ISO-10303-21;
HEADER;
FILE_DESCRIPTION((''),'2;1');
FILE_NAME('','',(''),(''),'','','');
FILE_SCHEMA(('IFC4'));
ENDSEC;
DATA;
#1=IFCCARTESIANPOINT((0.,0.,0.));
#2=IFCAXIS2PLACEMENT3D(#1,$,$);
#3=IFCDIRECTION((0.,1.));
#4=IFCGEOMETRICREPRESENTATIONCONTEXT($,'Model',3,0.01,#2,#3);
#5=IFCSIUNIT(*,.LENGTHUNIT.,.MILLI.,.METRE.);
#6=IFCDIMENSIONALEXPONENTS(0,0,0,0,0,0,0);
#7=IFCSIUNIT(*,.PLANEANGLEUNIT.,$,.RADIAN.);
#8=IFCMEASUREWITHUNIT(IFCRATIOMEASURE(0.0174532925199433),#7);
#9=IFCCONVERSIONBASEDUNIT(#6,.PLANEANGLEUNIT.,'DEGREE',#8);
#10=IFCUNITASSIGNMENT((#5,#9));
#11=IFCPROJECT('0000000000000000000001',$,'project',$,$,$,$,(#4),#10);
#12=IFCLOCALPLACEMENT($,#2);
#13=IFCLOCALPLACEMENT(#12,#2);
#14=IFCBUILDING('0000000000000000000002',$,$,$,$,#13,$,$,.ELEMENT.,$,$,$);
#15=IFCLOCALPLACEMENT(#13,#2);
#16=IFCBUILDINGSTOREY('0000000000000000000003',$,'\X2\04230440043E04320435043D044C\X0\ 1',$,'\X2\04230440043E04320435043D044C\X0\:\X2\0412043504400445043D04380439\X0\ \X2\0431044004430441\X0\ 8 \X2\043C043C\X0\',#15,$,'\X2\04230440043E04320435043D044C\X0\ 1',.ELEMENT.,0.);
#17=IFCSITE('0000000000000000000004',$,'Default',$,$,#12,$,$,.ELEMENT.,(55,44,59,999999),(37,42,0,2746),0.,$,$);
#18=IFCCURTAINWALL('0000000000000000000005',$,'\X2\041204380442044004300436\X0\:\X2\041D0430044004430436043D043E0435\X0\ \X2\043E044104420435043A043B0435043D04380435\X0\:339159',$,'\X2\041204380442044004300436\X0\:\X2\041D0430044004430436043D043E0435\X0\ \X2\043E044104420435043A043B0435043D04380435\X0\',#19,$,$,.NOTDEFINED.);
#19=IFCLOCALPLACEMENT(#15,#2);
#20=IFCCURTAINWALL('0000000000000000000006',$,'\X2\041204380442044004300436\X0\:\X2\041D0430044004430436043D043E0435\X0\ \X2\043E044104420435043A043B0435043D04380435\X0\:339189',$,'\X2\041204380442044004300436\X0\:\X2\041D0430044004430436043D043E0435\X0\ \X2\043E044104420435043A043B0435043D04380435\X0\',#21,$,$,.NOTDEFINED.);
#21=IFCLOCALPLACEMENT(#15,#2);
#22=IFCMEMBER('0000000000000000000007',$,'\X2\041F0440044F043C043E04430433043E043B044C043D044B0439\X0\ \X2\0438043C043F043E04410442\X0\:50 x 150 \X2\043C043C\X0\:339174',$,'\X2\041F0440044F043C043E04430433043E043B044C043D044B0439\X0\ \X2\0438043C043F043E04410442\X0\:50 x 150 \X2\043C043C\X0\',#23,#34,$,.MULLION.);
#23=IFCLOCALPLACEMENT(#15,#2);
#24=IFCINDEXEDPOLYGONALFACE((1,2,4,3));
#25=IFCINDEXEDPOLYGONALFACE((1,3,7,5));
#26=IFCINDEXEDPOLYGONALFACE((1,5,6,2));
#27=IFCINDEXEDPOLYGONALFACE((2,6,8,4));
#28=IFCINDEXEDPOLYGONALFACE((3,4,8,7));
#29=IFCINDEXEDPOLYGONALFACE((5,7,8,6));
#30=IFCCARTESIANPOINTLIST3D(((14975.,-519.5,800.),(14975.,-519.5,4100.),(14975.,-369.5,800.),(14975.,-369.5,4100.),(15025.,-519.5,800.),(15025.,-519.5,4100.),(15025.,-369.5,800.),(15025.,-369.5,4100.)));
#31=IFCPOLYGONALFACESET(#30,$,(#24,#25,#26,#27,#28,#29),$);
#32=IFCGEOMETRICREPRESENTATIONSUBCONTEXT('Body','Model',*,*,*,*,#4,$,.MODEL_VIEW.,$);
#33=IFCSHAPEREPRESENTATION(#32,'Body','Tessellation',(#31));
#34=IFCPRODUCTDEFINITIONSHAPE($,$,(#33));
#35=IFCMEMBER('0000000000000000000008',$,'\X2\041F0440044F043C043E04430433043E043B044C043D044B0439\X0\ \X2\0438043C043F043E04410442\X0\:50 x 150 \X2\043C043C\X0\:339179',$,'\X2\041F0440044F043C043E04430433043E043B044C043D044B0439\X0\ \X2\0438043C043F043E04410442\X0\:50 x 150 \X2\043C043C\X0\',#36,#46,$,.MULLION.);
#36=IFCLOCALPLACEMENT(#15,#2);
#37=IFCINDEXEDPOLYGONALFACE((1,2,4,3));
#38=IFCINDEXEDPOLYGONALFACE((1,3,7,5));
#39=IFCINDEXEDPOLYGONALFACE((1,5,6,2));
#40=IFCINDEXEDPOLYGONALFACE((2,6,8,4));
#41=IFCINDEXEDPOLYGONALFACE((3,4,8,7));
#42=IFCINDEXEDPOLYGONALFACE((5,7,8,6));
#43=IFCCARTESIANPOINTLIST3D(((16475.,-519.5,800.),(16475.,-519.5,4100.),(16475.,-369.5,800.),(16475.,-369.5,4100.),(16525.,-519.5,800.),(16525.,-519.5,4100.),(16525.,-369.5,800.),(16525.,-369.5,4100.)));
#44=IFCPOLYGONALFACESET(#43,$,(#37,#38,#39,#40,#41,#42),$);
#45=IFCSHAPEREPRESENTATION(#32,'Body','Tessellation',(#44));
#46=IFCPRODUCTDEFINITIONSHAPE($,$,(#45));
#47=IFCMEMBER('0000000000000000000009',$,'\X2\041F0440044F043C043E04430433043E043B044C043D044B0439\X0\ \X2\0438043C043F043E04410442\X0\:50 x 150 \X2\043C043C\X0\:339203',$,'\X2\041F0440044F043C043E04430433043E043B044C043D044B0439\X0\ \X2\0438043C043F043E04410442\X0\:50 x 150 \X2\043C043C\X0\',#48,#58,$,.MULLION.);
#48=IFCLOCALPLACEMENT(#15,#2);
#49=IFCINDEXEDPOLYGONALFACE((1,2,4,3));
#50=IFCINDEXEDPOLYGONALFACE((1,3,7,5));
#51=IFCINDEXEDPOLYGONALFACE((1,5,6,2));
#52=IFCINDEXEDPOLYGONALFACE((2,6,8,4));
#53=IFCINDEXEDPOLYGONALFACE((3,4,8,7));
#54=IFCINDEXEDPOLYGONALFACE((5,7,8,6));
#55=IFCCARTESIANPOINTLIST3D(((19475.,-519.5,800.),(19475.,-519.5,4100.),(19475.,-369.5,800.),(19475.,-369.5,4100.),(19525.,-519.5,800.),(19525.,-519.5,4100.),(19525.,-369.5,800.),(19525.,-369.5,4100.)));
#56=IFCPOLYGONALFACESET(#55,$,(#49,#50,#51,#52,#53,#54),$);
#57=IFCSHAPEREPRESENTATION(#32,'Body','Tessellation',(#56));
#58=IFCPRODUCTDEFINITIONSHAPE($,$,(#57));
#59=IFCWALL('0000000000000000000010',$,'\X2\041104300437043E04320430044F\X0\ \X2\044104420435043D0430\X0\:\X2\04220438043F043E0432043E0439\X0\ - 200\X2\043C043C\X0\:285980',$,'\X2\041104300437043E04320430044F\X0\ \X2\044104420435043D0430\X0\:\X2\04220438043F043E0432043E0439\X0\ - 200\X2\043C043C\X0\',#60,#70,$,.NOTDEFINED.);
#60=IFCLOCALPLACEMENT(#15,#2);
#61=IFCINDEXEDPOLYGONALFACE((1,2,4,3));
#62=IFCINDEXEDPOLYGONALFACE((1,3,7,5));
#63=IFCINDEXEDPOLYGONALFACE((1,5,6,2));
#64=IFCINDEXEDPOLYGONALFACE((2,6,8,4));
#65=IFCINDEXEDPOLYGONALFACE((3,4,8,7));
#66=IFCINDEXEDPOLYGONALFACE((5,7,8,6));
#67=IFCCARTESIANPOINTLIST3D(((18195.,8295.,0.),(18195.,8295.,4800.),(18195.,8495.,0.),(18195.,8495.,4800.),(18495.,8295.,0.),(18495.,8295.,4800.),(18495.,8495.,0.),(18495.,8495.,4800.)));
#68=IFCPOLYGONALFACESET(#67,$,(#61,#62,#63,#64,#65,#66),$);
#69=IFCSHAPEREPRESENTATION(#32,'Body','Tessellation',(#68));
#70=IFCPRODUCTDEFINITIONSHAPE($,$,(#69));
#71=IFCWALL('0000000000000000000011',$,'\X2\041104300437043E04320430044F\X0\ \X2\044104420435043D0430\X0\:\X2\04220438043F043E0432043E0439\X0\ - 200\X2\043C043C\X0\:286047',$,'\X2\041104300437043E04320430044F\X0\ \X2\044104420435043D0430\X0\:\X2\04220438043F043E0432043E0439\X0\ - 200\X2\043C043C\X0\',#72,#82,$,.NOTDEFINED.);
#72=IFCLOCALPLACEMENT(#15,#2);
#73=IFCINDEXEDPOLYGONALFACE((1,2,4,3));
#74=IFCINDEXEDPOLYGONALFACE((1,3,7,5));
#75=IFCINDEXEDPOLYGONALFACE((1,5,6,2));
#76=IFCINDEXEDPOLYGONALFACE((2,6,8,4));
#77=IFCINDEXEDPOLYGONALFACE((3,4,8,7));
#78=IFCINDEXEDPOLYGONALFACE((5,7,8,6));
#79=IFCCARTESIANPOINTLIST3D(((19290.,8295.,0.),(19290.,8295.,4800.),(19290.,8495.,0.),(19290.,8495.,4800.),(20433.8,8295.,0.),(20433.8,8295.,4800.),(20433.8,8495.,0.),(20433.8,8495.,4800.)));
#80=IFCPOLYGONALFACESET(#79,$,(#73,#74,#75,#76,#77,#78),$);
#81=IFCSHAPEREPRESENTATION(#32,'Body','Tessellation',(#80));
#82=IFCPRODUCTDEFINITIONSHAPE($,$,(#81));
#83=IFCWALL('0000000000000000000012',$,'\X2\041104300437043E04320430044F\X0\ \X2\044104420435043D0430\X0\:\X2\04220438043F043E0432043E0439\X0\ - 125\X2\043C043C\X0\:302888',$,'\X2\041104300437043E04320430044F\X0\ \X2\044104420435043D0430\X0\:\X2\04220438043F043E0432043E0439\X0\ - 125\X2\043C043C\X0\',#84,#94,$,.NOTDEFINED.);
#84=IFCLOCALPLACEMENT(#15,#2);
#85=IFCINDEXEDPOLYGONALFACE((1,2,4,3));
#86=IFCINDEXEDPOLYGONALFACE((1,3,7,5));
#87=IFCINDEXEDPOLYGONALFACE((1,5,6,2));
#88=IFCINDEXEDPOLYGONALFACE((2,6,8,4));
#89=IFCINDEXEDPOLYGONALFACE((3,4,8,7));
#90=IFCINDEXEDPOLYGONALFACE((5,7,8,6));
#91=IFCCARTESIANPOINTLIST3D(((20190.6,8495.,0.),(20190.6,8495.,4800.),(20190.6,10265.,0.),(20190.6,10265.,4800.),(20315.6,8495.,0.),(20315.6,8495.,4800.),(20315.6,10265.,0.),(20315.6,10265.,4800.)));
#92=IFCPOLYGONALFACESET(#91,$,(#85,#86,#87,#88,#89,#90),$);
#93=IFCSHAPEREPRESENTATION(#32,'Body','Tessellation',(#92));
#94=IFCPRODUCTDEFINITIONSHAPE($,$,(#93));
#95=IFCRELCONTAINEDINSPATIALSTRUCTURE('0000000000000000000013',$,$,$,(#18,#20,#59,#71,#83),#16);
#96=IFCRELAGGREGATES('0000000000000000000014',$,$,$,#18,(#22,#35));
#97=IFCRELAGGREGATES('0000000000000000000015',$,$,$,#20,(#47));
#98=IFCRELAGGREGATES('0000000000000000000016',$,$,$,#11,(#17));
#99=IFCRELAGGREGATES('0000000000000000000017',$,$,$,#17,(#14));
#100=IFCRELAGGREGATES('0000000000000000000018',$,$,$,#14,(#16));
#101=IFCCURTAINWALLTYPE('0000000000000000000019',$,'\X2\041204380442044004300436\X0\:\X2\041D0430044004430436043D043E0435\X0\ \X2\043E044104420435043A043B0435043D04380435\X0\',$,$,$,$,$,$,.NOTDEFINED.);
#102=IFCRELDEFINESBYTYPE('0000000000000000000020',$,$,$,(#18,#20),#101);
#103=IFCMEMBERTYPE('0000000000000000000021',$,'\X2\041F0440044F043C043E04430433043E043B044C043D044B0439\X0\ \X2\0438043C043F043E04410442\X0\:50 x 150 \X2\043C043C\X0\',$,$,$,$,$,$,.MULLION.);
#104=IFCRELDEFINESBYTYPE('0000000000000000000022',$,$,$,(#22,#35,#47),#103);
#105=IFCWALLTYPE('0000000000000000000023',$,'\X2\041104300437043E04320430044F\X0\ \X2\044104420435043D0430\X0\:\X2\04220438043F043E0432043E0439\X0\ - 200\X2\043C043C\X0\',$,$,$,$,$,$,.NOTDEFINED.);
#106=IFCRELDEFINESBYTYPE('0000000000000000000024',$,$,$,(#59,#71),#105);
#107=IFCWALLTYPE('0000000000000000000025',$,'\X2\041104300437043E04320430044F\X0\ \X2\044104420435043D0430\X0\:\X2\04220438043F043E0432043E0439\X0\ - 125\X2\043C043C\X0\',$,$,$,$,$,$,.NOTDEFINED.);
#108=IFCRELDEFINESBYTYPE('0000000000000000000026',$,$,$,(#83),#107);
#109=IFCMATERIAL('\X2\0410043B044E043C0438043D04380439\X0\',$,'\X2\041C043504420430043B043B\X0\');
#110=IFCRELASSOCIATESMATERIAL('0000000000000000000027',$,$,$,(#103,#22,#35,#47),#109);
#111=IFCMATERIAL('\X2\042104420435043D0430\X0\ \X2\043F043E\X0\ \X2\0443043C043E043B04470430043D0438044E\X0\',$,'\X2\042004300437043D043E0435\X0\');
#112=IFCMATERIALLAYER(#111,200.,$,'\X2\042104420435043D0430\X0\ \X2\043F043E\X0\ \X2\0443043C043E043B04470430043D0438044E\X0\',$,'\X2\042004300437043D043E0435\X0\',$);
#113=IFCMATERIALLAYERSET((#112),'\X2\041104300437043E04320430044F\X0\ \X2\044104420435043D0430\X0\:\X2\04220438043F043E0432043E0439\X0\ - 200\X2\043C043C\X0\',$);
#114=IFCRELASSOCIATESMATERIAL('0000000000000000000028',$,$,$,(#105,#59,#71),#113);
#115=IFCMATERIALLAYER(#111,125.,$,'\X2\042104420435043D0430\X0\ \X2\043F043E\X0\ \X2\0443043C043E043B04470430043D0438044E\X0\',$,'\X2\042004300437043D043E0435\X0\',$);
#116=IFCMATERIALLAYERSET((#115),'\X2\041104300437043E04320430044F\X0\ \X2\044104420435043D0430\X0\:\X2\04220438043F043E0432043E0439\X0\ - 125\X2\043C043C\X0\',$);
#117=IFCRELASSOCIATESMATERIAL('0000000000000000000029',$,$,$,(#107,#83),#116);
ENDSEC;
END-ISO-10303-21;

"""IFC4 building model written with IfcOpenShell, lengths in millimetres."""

from ifc_helpers import new_model, entity, si_unit, converted_unit, direction, frame, frame_2d, origin, origin_2d_with_axis, place, context, subcontext, project, spatial, rectangle, extrude, source, transform, mapped, material, layer, layer_set, layer_usage, material_profile, profile_set, profile_usage, type_object, type_shapes, element, aggregate, save


model = new_model("IFC4")

# Units and contexts
model_context = context("Model", 3, precision=0.01, world=origin(), true_north=direction((0.0, 1.0)))
body_context = subcontext(model_context, "Body", "Model", "MODEL_VIEW")
ifc_project = project(units=[si_unit("LENGTHUNIT", "METRE", prefix="MILLI"), converted_unit("PLANEANGLEUNIT", "DEGREE", entity("IfcRatioMeasure", 0.0174532925199433), si_unit("PLANEANGLEUNIT", "RADIAN"), dimensions=[0, 0, 0, 0, 0, 0, 0])], contexts=[model_context])

# Site, building, storey
site_placement = place(None, origin())
site = spatial("IfcSite", under=ifc_project, at=site_placement, Name="Default", CompositionType="ELEMENT", RefLatitude=(55, 44, 59, 999999), RefLongitude=(37, 42, 0, 2746), RefElevation=0.0)
building_placement = place(site_placement, origin())
building = spatial("IfcBuilding", under=site, at=building_placement, CompositionType="ELEMENT")
storey_placement = place(building_placement, origin())
storey = spatial("IfcBuildingStorey", under=building, at=storey_placement, Name="Уровень 1", ObjectType="Уровень:Верхний брус 8 мм", LongName="Уровень 1", CompositionType="ELEMENT", Elevation=0.0)

# Curtain wall
curtain_wall_type = type_object("IfcCurtainWallType", Name="Витраж:Наружное остекление", PredefinedType="NOTDEFINED")
curtain_wall_1_placement = place(storey_placement, origin())
curtain_wall_1 = element("IfcCurtainWall", 1, at=curtain_wall_1_placement, inside=storey, type_object=curtain_wall_type, Name="Витраж:Наружное остекление:339159", ObjectType="Витраж:Наружное остекление", PredefinedType="NOTDEFINED")
ifc_material_1 = material(Name="Алюминий", Category="Металл")
ifc_material_profile = material_profile(ifc_material_1, rectangle(XDim=150.0, YDim=50.0, at=origin_2d_with_axis()), Name="50 x 150 мм")
ifc_profile_set = profile_set([ifc_material_profile], Name="50 x 150 мм")

# Curtain wall
curtain_wall_2_placement = place(storey_placement, origin())
curtain_wall_2 = element("IfcCurtainWall", 2, at=curtain_wall_2_placement, inside=storey, type_object=curtain_wall_type, Name="Витраж:Наружное остекление:339189", ObjectType="Витраж:Наружное остекление", PredefinedType="NOTDEFINED")

# Members
member_type_1 = type_object("IfcMemberType", Name="Прямоугольный импост:50 x 150 мм", PredefinedType="MULLION", material=ifc_profile_set)
shared_shape_1 = source(origin(), body_context, "Body", "SweptSolid", [
    extrude(rectangle(XDim=150.0, YDim=50.0, at=origin_2d_with_axis()), frame((0.0, 0.0, -3300.0), z_axis=(0.0, 0.0, 1.0), x_axis=(0.0, -1.0, 0.0)), (0.0, 0.0, 1.0), 3300.0),
])
type_shapes(member_type_1, [shared_shape_1])
ifc_profile_usage_1 = profile_usage(ifc_profile_set)
member_1_placement = place(storey_placement, frame((15000.0, -444.5, 800.0), z_axis=(0.0, 0.0, -1.0), x_axis=(1.0, 0.0, 0.0)))
member_1 = element("IfcMember", 3, at=member_1_placement, type_object=member_type_1, material=ifc_profile_usage_1, Name="Прямоугольный импост:50 x 150 мм:339174", ObjectType="Прямоугольный импост:50 x 150 мм", PredefinedType="MULLION", context=body_context, shape_type="MappedRepresentation", body=[
    mapped(shared_shape_1, transform((0.0, 0.0, 0.0), scale=1.0)),
])
ifc_profile_usage_2 = profile_usage(ifc_profile_set)
member_2_placement = place(storey_placement, frame((16500.0, -444.5, 800.0), z_axis=(0.0, 0.0, -1.0), x_axis=(1.0, 0.0, 0.0)))
member_2 = element("IfcMember", 4, at=member_2_placement, type_object=member_type_1, material=ifc_profile_usage_2, Name="Прямоугольный импост:50 x 150 мм:339179", ObjectType="Прямоугольный импост:50 x 150 мм", PredefinedType="MULLION", context=body_context, shape_type="MappedRepresentation", body=[
    mapped(shared_shape_1, transform((0.0, 0.0, 0.0), scale=1.0)),
])
ifc_profile_usage_3 = profile_usage(ifc_profile_set)
member_3_placement = place(storey_placement, frame((19500.0, -444.5, 800.0), z_axis=(0.0, 0.0, -1.0), x_axis=(1.0, 0.0, 0.0)))
member_3 = element("IfcMember", 5, at=member_3_placement, type_object=member_type_1, material=ifc_profile_usage_3, Name="Прямоугольный импост:50 x 150 мм:339203", ObjectType="Прямоугольный импост:50 x 150 мм", PredefinedType="MULLION", context=body_context, shape_type="MappedRepresentation", body=[
    mapped(shared_shape_1, transform((0.0, 0.0, 0.0), scale=1.0)),
])

aggregate(curtain_wall_1, [member_1, member_2])
aggregate(curtain_wall_2, [member_3])

# Walls
ifc_material_2 = material(Name="Стена по умолчанию", Category="Разное")
ifc_layer_1 = layer(ifc_material_2, 200.0, Name="Стена по умолчанию", Category="Разное")
ifc_layer_set_1 = layer_set([ifc_layer_1], Name="Базовая стена:Типовой - 200мм")
ifc_layer_usage_1 = layer_usage(ifc_layer_set_1, "AXIS2", "NEGATIVE", 100.0)
wall_type_1 = type_object("IfcWallType", Name="Базовая стена:Типовой - 200мм", PredefinedType="NOTDEFINED", material=ifc_layer_set_1)
wall_1_placement = place(storey_placement, frame((18195.0, 8395.0, 0.0)))
element("IfcWall", 6, at=wall_1_placement, inside=storey, type_object=wall_type_1, material=ifc_layer_usage_1, Name="Базовая стена:Типовой - 200мм:285980", ObjectType="Базовая стена:Типовой - 200мм", PredefinedType="NOTDEFINED", context=body_context, shape_type="SweptSolid", body=[
    extrude(rectangle(XDim=300.0, YDim=200.0, at=frame_2d((150.0, 0.0), x_axis=(-1.0, 0.0))), origin(), (0.0, 0.0, 1.0), 4800.0),
])
ifc_layer_usage_2 = layer_usage(ifc_layer_set_1, "AXIS2", "NEGATIVE", 100.0)
wall_2_placement = place(storey_placement, frame((19290.0, 8395.0, 0.0)))
element("IfcWall", 7, at=wall_2_placement, inside=storey, type_object=wall_type_1, material=ifc_layer_usage_2, Name="Базовая стена:Типовой - 200мм:286047", ObjectType="Базовая стена:Типовой - 200мм", PredefinedType="NOTDEFINED", context=body_context, shape_type="SweptSolid", body=[
    extrude(rectangle(XDim=1143.8, YDim=200.0, at=frame_2d((571.9, 0.0), x_axis=(-1.0, 0.0))), origin(), (0.0, 0.0, 1.0), 4800.0),
])
ifc_layer_2 = layer(ifc_material_2, 125.0, Name="Стена по умолчанию", Category="Разное")
ifc_layer_set_2 = layer_set([ifc_layer_2], Name="Базовая стена:Типовой - 125мм")
ifc_layer_usage_3 = layer_usage(ifc_layer_set_2, "AXIS2", "NEGATIVE", 62.5)
wall_type_2 = type_object("IfcWallType", Name="Базовая стена:Типовой - 125мм", PredefinedType="NOTDEFINED", material=ifc_layer_set_2)
wall_3_placement = place(storey_placement, frame((20253.1, 8495.0, 0.0), z_axis=(0.0, 0.0, 1.0), x_axis=(0.0, 1.0, 0.0)))
element("IfcWall", 8, at=wall_3_placement, inside=storey, type_object=wall_type_2, material=ifc_layer_usage_3, Name="Базовая стена:Типовой - 125мм:302888", ObjectType="Базовая стена:Типовой - 125мм", PredefinedType="NOTDEFINED", context=body_context, shape_type="SweptSolid", body=[
    extrude(rectangle(XDim=1770.0, YDim=125.0, at=frame_2d((885.0, 0.0), x_axis=(-1.0, 0.0))), origin(), (0.0, 0.0, 1.0), 4800.0),
])

save(model, "model.ifc")
